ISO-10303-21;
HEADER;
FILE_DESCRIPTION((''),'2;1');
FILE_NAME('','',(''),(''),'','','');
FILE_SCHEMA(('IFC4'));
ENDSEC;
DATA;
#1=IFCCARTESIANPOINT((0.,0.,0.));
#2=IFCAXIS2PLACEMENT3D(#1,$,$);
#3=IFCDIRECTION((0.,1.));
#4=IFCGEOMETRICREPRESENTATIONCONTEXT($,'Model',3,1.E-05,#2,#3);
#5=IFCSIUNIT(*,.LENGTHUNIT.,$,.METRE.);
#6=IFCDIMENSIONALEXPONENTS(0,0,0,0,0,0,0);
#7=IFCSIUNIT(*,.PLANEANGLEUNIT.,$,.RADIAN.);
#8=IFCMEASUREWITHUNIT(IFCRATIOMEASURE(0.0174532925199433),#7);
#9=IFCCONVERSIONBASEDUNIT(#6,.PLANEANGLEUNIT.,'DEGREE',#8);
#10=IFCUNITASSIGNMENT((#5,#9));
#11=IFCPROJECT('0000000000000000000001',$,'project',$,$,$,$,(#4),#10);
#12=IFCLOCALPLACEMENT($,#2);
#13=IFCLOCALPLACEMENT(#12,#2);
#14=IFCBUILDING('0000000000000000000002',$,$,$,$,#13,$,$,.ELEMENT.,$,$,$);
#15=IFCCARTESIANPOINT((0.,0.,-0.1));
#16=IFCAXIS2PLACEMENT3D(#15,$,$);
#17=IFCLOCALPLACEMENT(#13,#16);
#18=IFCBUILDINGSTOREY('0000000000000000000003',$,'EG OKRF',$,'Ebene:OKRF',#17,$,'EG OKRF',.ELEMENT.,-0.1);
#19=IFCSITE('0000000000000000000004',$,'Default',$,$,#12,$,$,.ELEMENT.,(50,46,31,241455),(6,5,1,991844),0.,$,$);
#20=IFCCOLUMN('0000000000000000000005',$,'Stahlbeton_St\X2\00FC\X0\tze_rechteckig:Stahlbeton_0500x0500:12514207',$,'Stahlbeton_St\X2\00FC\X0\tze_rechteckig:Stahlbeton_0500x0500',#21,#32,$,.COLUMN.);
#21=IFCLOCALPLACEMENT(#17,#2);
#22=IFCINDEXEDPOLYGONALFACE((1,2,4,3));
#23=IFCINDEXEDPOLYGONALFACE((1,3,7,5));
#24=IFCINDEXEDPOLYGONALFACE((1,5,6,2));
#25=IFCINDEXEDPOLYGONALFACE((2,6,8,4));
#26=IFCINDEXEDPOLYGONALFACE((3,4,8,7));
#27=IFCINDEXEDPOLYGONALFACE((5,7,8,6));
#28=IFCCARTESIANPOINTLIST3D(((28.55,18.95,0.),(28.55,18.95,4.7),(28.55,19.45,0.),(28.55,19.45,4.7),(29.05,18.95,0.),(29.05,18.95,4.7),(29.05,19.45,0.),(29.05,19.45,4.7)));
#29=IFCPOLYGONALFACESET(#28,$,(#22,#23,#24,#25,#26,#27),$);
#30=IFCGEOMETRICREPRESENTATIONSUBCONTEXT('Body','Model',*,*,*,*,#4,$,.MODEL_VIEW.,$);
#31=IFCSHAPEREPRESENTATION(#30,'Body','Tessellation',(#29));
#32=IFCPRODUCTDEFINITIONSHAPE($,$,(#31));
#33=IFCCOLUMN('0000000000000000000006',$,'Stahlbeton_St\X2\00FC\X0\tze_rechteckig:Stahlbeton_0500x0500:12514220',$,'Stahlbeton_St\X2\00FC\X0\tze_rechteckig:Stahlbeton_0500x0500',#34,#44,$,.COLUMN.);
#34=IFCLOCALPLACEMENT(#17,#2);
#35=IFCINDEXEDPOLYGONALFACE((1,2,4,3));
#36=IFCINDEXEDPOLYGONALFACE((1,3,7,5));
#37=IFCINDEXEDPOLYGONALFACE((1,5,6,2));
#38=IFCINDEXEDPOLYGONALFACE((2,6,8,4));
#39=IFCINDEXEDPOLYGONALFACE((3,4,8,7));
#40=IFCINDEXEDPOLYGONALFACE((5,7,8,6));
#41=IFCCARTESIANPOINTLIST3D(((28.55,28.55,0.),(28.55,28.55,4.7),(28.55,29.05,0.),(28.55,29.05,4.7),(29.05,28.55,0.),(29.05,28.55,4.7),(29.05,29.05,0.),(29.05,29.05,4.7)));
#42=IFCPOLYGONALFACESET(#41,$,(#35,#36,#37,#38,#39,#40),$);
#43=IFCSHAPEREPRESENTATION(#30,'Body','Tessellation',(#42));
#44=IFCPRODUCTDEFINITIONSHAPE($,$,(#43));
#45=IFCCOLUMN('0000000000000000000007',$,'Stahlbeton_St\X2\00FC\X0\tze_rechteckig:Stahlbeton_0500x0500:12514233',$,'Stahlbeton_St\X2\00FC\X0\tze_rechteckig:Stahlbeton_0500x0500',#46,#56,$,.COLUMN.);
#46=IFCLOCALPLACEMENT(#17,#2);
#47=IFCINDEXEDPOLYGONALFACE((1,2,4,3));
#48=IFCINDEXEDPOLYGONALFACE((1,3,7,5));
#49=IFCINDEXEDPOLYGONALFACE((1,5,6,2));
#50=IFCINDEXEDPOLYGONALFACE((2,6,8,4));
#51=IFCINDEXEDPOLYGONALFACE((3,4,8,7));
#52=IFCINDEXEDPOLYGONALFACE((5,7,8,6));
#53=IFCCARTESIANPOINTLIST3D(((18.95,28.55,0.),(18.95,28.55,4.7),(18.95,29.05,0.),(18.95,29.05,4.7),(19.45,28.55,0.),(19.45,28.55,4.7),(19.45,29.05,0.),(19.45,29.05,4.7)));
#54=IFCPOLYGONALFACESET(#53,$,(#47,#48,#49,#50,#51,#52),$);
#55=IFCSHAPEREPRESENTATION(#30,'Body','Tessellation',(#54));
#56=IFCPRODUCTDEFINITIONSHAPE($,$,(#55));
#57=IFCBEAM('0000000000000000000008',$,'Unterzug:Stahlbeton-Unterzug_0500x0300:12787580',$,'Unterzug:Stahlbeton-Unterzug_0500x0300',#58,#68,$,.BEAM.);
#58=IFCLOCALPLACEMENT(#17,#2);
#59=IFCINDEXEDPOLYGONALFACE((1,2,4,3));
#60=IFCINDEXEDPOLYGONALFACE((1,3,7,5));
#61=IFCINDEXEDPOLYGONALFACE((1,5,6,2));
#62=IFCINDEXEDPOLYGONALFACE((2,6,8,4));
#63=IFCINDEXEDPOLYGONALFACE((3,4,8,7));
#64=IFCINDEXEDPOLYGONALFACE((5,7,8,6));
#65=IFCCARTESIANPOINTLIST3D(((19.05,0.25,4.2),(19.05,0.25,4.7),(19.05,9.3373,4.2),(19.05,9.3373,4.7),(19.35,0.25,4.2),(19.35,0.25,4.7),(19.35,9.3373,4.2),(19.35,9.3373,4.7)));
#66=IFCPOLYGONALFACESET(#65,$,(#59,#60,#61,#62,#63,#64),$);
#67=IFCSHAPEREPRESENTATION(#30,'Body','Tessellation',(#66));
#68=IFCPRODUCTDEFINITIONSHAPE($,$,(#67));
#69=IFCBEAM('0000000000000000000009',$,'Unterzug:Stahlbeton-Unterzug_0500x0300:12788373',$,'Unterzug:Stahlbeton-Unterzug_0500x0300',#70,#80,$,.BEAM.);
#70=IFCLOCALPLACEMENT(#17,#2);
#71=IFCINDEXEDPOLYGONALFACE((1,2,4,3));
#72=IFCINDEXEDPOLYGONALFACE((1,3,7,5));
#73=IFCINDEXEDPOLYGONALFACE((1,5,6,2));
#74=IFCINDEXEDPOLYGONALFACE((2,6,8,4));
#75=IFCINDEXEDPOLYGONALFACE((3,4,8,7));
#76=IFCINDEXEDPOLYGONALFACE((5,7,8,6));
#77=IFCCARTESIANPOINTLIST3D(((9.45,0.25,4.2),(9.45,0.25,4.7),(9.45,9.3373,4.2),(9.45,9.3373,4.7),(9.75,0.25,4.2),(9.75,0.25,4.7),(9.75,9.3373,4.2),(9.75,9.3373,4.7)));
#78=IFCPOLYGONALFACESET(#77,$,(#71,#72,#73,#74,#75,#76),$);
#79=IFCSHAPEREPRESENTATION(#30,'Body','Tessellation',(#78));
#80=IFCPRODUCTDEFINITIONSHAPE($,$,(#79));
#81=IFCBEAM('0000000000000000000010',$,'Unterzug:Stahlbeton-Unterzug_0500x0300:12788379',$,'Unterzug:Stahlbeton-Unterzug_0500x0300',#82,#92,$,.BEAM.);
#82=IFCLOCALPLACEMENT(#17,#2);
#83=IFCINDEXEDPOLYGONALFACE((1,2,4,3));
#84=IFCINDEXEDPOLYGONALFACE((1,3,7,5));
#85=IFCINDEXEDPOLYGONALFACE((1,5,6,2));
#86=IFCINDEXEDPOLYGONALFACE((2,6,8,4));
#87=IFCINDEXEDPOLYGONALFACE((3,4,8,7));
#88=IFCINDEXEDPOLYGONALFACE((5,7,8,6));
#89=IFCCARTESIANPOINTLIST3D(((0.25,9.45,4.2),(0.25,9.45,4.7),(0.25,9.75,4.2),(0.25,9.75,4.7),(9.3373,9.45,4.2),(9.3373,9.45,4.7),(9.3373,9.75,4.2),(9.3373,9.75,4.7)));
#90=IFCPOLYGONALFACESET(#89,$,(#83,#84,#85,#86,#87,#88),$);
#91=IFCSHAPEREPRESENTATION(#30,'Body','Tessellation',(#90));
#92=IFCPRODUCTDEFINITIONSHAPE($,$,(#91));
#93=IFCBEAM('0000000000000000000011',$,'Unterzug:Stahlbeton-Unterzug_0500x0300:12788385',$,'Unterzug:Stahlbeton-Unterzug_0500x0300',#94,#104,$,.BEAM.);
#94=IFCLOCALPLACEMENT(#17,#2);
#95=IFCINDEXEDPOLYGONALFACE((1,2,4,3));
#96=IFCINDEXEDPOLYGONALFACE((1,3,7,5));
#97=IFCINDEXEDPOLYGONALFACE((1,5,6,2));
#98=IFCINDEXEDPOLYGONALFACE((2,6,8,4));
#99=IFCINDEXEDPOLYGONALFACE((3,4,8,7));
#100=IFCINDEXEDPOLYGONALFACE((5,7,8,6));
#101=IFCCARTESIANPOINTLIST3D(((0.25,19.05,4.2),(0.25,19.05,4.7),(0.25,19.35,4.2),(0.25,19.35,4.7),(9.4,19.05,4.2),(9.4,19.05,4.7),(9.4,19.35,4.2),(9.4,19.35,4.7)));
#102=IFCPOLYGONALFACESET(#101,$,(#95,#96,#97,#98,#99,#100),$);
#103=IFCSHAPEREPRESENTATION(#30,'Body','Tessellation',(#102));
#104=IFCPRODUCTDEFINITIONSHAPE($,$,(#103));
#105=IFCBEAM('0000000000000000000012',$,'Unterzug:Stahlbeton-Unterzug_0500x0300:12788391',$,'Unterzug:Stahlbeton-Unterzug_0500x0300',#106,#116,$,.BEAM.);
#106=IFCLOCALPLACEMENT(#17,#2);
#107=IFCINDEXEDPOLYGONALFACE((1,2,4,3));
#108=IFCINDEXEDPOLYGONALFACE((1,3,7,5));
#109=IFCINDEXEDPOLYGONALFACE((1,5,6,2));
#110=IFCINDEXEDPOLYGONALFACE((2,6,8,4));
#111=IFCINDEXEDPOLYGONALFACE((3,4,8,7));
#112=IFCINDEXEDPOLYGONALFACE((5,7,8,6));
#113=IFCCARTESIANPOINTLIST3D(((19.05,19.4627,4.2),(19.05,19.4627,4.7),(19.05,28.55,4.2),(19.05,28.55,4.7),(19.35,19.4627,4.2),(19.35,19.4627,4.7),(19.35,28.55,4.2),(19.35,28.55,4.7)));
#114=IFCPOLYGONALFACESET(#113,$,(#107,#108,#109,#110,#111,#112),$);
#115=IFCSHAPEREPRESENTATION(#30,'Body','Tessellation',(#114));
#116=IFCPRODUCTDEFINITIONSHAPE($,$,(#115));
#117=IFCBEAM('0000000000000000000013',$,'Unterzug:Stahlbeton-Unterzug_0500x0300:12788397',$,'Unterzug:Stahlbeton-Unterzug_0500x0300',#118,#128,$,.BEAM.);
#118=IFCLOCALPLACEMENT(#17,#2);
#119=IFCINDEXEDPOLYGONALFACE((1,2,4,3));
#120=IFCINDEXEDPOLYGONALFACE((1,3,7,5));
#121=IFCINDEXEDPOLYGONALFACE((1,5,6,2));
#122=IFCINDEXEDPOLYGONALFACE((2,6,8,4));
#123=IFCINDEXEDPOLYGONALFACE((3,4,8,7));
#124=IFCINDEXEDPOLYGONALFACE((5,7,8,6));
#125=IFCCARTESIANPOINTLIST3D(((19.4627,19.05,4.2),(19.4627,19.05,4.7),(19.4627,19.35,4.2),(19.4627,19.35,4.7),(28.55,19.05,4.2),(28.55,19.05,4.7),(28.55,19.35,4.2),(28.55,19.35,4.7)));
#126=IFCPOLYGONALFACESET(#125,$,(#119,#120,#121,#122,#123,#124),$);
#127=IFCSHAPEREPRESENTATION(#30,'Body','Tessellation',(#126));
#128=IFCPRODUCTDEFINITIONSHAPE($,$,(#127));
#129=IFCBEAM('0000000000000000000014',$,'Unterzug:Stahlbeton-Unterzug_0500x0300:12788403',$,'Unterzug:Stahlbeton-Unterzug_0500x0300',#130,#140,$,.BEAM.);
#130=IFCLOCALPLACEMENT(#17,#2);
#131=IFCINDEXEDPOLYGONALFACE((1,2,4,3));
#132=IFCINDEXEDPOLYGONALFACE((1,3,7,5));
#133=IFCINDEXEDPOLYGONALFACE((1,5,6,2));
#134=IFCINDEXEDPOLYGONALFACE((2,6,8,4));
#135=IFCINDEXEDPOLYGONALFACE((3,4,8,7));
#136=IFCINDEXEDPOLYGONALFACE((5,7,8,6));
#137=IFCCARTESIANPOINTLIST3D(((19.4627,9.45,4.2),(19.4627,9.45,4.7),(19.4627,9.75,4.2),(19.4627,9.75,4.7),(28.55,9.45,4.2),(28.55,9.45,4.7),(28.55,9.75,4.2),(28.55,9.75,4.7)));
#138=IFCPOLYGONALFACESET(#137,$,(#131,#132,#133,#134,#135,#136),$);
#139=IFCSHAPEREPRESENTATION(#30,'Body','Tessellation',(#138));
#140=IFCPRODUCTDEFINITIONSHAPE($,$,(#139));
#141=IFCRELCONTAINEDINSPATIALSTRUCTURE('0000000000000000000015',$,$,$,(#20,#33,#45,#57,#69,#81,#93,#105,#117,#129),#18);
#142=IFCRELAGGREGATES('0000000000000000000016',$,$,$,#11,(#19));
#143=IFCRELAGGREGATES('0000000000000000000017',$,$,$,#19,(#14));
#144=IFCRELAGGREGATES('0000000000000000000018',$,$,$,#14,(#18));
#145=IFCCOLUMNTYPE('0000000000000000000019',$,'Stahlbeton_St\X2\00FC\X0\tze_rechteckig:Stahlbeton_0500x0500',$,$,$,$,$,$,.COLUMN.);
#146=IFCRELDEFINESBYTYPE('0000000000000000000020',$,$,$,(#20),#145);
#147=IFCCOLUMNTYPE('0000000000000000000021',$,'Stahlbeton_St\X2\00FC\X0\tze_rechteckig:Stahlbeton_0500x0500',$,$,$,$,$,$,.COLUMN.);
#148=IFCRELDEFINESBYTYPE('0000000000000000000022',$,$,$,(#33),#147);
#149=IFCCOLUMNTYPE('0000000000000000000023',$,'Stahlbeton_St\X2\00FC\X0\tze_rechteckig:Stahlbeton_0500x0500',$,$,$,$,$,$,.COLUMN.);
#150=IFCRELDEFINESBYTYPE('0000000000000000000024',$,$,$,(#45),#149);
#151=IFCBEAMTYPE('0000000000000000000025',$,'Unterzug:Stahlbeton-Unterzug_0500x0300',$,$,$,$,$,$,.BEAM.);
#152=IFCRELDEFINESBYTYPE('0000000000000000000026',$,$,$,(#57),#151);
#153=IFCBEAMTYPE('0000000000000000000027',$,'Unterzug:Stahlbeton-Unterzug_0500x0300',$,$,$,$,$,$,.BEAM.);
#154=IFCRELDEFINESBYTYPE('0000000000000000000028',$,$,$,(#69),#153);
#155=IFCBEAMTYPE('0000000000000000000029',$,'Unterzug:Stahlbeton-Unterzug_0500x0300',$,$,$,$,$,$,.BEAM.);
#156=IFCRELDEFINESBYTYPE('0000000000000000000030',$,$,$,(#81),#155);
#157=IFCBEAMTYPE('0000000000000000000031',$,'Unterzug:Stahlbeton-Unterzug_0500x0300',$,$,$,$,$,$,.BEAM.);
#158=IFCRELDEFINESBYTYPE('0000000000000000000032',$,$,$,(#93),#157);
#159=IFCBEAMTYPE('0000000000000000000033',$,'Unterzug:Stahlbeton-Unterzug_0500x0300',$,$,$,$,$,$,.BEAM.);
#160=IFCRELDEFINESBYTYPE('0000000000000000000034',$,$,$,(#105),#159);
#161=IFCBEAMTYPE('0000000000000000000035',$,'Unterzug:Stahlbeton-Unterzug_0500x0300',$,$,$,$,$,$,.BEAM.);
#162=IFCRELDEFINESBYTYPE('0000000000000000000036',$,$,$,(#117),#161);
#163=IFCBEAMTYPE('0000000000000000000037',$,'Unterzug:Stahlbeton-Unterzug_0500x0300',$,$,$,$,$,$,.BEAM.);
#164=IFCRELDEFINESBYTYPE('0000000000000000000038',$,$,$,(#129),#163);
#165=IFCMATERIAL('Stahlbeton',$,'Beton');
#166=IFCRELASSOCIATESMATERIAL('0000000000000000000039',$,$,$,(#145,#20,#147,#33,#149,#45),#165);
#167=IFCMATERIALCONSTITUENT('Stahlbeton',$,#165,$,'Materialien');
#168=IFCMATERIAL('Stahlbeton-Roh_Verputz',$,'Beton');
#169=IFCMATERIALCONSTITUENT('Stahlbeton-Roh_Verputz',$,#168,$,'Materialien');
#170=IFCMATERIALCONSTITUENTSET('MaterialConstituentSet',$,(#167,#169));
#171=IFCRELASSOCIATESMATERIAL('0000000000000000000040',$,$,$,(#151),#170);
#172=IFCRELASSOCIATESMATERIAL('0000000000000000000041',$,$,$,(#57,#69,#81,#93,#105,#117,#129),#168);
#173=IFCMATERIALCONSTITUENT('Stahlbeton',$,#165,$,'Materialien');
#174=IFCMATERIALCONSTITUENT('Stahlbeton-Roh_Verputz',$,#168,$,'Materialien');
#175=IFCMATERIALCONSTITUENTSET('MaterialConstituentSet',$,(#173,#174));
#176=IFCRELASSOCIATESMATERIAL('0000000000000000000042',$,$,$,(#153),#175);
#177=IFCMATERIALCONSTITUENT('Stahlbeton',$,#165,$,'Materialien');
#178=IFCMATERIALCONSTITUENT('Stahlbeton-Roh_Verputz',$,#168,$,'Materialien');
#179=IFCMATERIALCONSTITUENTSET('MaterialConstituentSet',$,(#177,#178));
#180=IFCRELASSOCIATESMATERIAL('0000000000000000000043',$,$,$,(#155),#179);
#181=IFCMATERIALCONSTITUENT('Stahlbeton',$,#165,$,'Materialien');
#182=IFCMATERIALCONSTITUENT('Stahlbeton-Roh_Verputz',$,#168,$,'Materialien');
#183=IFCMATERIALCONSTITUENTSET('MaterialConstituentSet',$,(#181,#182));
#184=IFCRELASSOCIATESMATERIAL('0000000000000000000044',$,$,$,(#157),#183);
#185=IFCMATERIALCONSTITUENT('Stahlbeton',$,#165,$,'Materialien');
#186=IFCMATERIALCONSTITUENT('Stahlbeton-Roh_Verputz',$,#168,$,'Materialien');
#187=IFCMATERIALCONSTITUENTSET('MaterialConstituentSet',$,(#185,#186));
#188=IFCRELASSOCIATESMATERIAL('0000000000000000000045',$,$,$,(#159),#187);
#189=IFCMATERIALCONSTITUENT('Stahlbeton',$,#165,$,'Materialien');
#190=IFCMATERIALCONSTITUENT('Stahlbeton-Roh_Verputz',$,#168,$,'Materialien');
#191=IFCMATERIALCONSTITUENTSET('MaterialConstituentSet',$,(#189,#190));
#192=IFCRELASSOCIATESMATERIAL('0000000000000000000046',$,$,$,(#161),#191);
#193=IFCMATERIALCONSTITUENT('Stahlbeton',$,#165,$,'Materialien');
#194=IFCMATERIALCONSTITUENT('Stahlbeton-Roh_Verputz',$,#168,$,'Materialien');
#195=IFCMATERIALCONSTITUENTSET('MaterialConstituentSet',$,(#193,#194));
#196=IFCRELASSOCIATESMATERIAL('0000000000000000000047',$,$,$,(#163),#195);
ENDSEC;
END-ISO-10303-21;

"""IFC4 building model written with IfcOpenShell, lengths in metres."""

from ifc_helpers import new_model, entity, si_unit, converted_unit, direction, frame, origin, place, context, subcontext, project, spatial, indexed_curve, outline, extrude, source, transform, mapped, material, constituent, constituent_set, type_object, type_shapes, element, save


model = new_model("IFC4")

# Units and contexts
model_context = context("Model", 3, precision=1e-05, world=origin(), true_north=direction((0.0, 1.0)))
body_context = subcontext(model_context, "Body", "Model", "MODEL_VIEW")
ifc_project = project(units=[si_unit("LENGTHUNIT", "METRE"), converted_unit("PLANEANGLEUNIT", "DEGREE", entity("IfcRatioMeasure", 0.0174532925199433), si_unit("PLANEANGLEUNIT", "RADIAN"), dimensions=[0, 0, 0, 0, 0, 0, 0])], contexts=[model_context])

# Site, building, storey
site_placement = place(None, origin())
site = spatial("IfcSite", under=ifc_project, at=site_placement, Name="Default", CompositionType="ELEMENT", RefLatitude=(50, 46, 31, 241455), RefLongitude=(6, 5, 1, 991844), RefElevation=0.0)
building_placement = place(site_placement, origin())
building = spatial("IfcBuilding", under=site, at=building_placement, CompositionType="ELEMENT")
storey_placement = place(building_placement, frame((0.0, 0.0, -0.1)))
storey = spatial("IfcBuildingStorey", under=building, at=storey_placement, Name="EG OKRF", ObjectType="Ebene:OKRF", LongName="EG OKRF", CompositionType="ELEMENT", Elevation=-0.1)

# Columns
ifc_material_1 = material(Name="Stahlbeton", Category="Beton")
column_type_1 = type_object("IfcColumnType", Name="Stahlbeton_Stütze_rechteckig:Stahlbeton_0500x0500", PredefinedType="COLUMN", material=ifc_material_1)
shared_shape_1 = source(origin(), body_context, "Body", "SweptSolid", [
    extrude(outline(indexed_curve([(-0.25, -0.25), (0.25, -0.25), (0.25, 0.25), (-0.25, 0.25), (-0.25, -0.25)], self_intersect=False)), frame((28.8, 19.2, -0.1), z_axis=(0.0, 0.0, 1.0), x_axis=(0.0, -1.0, 0.0)), (0.0, 0.0, 1.0), 4.7),
])
type_shapes(column_type_1, [shared_shape_1])
column_1_placement = place(storey_placement, frame((0.0, 0.0, 0.1)))
element("IfcColumn", 1, at=column_1_placement, inside=storey, type_object=column_type_1, material=ifc_material_1, Name="Stahlbeton_Stütze_rechteckig:Stahlbeton_0500x0500:12514207", ObjectType="Stahlbeton_Stütze_rechteckig:Stahlbeton_0500x0500", PredefinedType="COLUMN", context=body_context, shape_type="MappedRepresentation", body=[
    mapped(shared_shape_1, transform((0.0, 0.0, 0.0), scale=1.0)),
])
column_type_2 = type_object("IfcColumnType", Name="Stahlbeton_Stütze_rechteckig:Stahlbeton_0500x0500", PredefinedType="COLUMN", material=ifc_material_1)
shared_shape_2 = source(origin(), body_context, "Body", "SweptSolid", [
    extrude(outline(indexed_curve([(-0.25, -0.25), (0.25, -0.25), (0.25, 0.25), (-0.25, 0.25), (-0.25, -0.25)], self_intersect=False)), frame((28.8, 28.8, -0.1), z_axis=(0.0, 0.0, 1.0), x_axis=(0.0, -1.0, 0.0)), (0.0, 0.0, 1.0), 4.7),
])
type_shapes(column_type_2, [shared_shape_2])
column_2_placement = place(storey_placement, frame((0.0, 0.0, 0.1)))
element("IfcColumn", 2, at=column_2_placement, inside=storey, type_object=column_type_2, material=ifc_material_1, Name="Stahlbeton_Stütze_rechteckig:Stahlbeton_0500x0500:12514220", ObjectType="Stahlbeton_Stütze_rechteckig:Stahlbeton_0500x0500", PredefinedType="COLUMN", context=body_context, shape_type="MappedRepresentation", body=[
    mapped(shared_shape_2, transform((0.0, 0.0, 0.0), scale=1.0)),
])
column_type_3 = type_object("IfcColumnType", Name="Stahlbeton_Stütze_rechteckig:Stahlbeton_0500x0500", PredefinedType="COLUMN", material=ifc_material_1)
shared_shape_3 = source(origin(), body_context, "Body", "SweptSolid", [
    extrude(outline(indexed_curve([(-0.25, -0.25), (0.25, -0.25), (0.25, 0.25), (-0.25, 0.25), (-0.25, -0.25)], self_intersect=False)), frame((19.2, 28.8, -0.1), z_axis=(0.0, 0.0, 1.0), x_axis=(0.0, -1.0, 0.0)), (0.0, 0.0, 1.0), 4.7),
])
type_shapes(column_type_3, [shared_shape_3])
column_3_placement = place(storey_placement, frame((0.0, 0.0, 0.1)))
element("IfcColumn", 3, at=column_3_placement, inside=storey, type_object=column_type_3, material=ifc_material_1, Name="Stahlbeton_Stütze_rechteckig:Stahlbeton_0500x0500:12514233", ObjectType="Stahlbeton_Stütze_rechteckig:Stahlbeton_0500x0500", PredefinedType="COLUMN", context=body_context, shape_type="MappedRepresentation", body=[
    mapped(shared_shape_3, transform((0.0, 0.0, 0.0), scale=1.0)),
])

# Beams
ifc_material_2 = material(Name="Stahlbeton-Roh_Verputz", Category="Beton")
ifc_constituent_1 = constituent(ifc_material_1, Name="Stahlbeton", Category="Materialien")
ifc_constituent_2 = constituent(ifc_material_2, Name="Stahlbeton-Roh_Verputz", Category="Materialien")
ifc_constituent_set_1 = constituent_set(constituents=[ifc_constituent_1, ifc_constituent_2], Name="MaterialConstituentSet")
beam_type_1 = type_object("IfcBeamType", Name="Unterzug:Stahlbeton-Unterzug_0500x0300", PredefinedType="BEAM", material=ifc_constituent_set_1)
shared_shape_4 = source(origin(), body_context, "Body", "SweptSolid", [
    extrude(outline(indexed_curve([(-0.15, -0.25), (0.15, -0.25), (0.15, 0.25), (-0.15, 0.25), (-0.15, -0.25)], self_intersect=False)), frame((19.2, 9.3373, 4.35), z_axis=(0.0, -1.0, 0.0), x_axis=(-1.0, 0.0, 0.0)), (0.0, 0.0, 1.0), 9.0873),
])
type_shapes(beam_type_1, [shared_shape_4])
beam_1_placement = place(storey_placement, frame((0.0, 0.0, 0.1)))
element("IfcBeam", 4, at=beam_1_placement, inside=storey, type_object=beam_type_1, material=ifc_material_2, Name="Unterzug:Stahlbeton-Unterzug_0500x0300:12787580", ObjectType="Unterzug:Stahlbeton-Unterzug_0500x0300", PredefinedType="BEAM", context=body_context, shape_type="MappedRepresentation", body=[
    mapped(shared_shape_4, transform((0.0, 0.0, 0.0), scale=1.0)),
])
ifc_constituent_3 = constituent(ifc_material_1, Name="Stahlbeton", Category="Materialien")
ifc_constituent_4 = constituent(ifc_material_2, Name="Stahlbeton-Roh_Verputz", Category="Materialien")
ifc_constituent_set_2 = constituent_set(constituents=[ifc_constituent_3, ifc_constituent_4], Name="MaterialConstituentSet")
beam_type_2 = type_object("IfcBeamType", Name="Unterzug:Stahlbeton-Unterzug_0500x0300", PredefinedType="BEAM", material=ifc_constituent_set_2)
shared_shape_5 = source(origin(), body_context, "Body", "SweptSolid", [
    extrude(outline(indexed_curve([(-0.15, -0.25), (0.15, -0.25), (0.15, 0.25), (-0.15, 0.25), (-0.15, -0.25)], self_intersect=False)), frame((9.6, 9.3373, 4.35), z_axis=(0.0, -1.0, 0.0), x_axis=(-1.0, 0.0, 0.0)), (0.0, 0.0, 1.0), 9.0873),
])
type_shapes(beam_type_2, [shared_shape_5])
beam_2_placement = place(storey_placement, frame((0.0, 0.0, 0.1)))
element("IfcBeam", 5, at=beam_2_placement, inside=storey, type_object=beam_type_2, material=ifc_material_2, Name="Unterzug:Stahlbeton-Unterzug_0500x0300:12788373", ObjectType="Unterzug:Stahlbeton-Unterzug_0500x0300", PredefinedType="BEAM", context=body_context, shape_type="MappedRepresentation", body=[
    mapped(shared_shape_5, transform((0.0, 0.0, 0.0), scale=1.0)),
])
ifc_constituent_5 = constituent(ifc_material_1, Name="Stahlbeton", Category="Materialien")
ifc_constituent_6 = constituent(ifc_material_2, Name="Stahlbeton-Roh_Verputz", Category="Materialien")
ifc_constituent_set_3 = constituent_set(constituents=[ifc_constituent_5, ifc_constituent_6], Name="MaterialConstituentSet")
beam_type_3 = type_object("IfcBeamType", Name="Unterzug:Stahlbeton-Unterzug_0500x0300", PredefinedType="BEAM", material=ifc_constituent_set_3)
shared_shape_6 = source(origin(), body_context, "Body", "SweptSolid", [
    extrude(outline(indexed_curve([(-0.25, -0.15), (0.25, -0.15), (0.25, 0.15), (-0.25, 0.15), (-0.25, -0.15)], self_intersect=False)), frame((9.3373, 9.6, 4.35), z_axis=(-1.0, 0.0, 0.0), x_axis=(0.0, 0.0, -1.0)), (0.0, 0.0, 1.0), 9.0873),
])
type_shapes(beam_type_3, [shared_shape_6])
beam_3_placement = place(storey_placement, frame((0.0, 0.0, 0.1)))
element("IfcBeam", 6, at=beam_3_placement, inside=storey, type_object=beam_type_3, material=ifc_material_2, Name="Unterzug:Stahlbeton-Unterzug_0500x0300:12788379", ObjectType="Unterzug:Stahlbeton-Unterzug_0500x0300", PredefinedType="BEAM", context=body_context, shape_type="MappedRepresentation", body=[
    mapped(shared_shape_6, transform((0.0, 0.0, 0.0), scale=1.0)),
])
ifc_constituent_7 = constituent(ifc_material_1, Name="Stahlbeton", Category="Materialien")
ifc_constituent_8 = constituent(ifc_material_2, Name="Stahlbeton-Roh_Verputz", Category="Materialien")
ifc_constituent_set_4 = constituent_set(constituents=[ifc_constituent_7, ifc_constituent_8], Name="MaterialConstituentSet")
beam_type_4 = type_object("IfcBeamType", Name="Unterzug:Stahlbeton-Unterzug_0500x0300", PredefinedType="BEAM", material=ifc_constituent_set_4)
shared_shape_7 = source(origin(), body_context, "Body", "SweptSolid", [
    extrude(outline(indexed_curve([(-0.25, -0.15), (0.25, -0.15), (0.25, 0.15), (-0.25, 0.15), (-0.25, -0.15)], self_intersect=False)), frame((9.4, 19.2, 4.35), z_axis=(-1.0, 0.0, 0.0), x_axis=(0.0, 0.0, -1.0)), (0.0, 0.0, 1.0), 9.15),
])
type_shapes(beam_type_4, [shared_shape_7])
beam_4_placement = place(storey_placement, frame((0.0, 0.0, 0.1)))
element("IfcBeam", 7, at=beam_4_placement, inside=storey, type_object=beam_type_4, material=ifc_material_2, Name="Unterzug:Stahlbeton-Unterzug_0500x0300:12788385", ObjectType="Unterzug:Stahlbeton-Unterzug_0500x0300", PredefinedType="BEAM", context=body_context, shape_type="MappedRepresentation", body=[
    mapped(shared_shape_7, transform((0.0, 0.0, 0.0), scale=1.0)),
])
ifc_constituent_9 = constituent(ifc_material_1, Name="Stahlbeton", Category="Materialien")
ifc_constituent_10 = constituent(ifc_material_2, Name="Stahlbeton-Roh_Verputz", Category="Materialien")
ifc_constituent_set_5 = constituent_set(constituents=[ifc_constituent_9, ifc_constituent_10], Name="MaterialConstituentSet")
beam_type_5 = type_object("IfcBeamType", Name="Unterzug:Stahlbeton-Unterzug_0500x0300", PredefinedType="BEAM", material=ifc_constituent_set_5)
shared_shape_8 = source(origin(), body_context, "Body", "SweptSolid", [
    extrude(outline(indexed_curve([(-0.15, -0.25), (0.15, -0.25), (0.15, 0.25), (-0.15, 0.25), (-0.15, -0.25)], self_intersect=False)), frame((19.2, 19.4627, 4.35), z_axis=(0.0, 1.0, 0.0), x_axis=(-1.0, 0.0, 0.0)), (0.0, 0.0, 1.0), 9.0873),
])
type_shapes(beam_type_5, [shared_shape_8])
beam_5_placement = place(storey_placement, frame((0.0, 0.0, 0.1)))
element("IfcBeam", 8, at=beam_5_placement, inside=storey, type_object=beam_type_5, material=ifc_material_2, Name="Unterzug:Stahlbeton-Unterzug_0500x0300:12788391", ObjectType="Unterzug:Stahlbeton-Unterzug_0500x0300", PredefinedType="BEAM", context=body_context, shape_type="MappedRepresentation", body=[
    mapped(shared_shape_8, transform((0.0, 0.0, 0.0), scale=1.0)),
])
ifc_constituent_11 = constituent(ifc_material_1, Name="Stahlbeton", Category="Materialien")
ifc_constituent_12 = constituent(ifc_material_2, Name="Stahlbeton-Roh_Verputz", Category="Materialien")
ifc_constituent_set_6 = constituent_set(constituents=[ifc_constituent_11, ifc_constituent_12], Name="MaterialConstituentSet")
beam_type_6 = type_object("IfcBeamType", Name="Unterzug:Stahlbeton-Unterzug_0500x0300", PredefinedType="BEAM", material=ifc_constituent_set_6)
shared_shape_9 = source(origin(), body_context, "Body", "SweptSolid", [
    extrude(outline(indexed_curve([(-0.25, -0.15), (0.25, -0.15), (0.25, 0.15), (-0.25, 0.15), (-0.25, -0.15)], self_intersect=False)), frame((19.4627, 19.2, 4.35), z_axis=(1.0, 0.0, 0.0), x_axis=(0.0, 0.0, -1.0)), (0.0, 0.0, 1.0), 9.0873),
])
type_shapes(beam_type_6, [shared_shape_9])
beam_6_placement = place(storey_placement, frame((0.0, 0.0, 0.1)))
element("IfcBeam", 9, at=beam_6_placement, inside=storey, type_object=beam_type_6, material=ifc_material_2, Name="Unterzug:Stahlbeton-Unterzug_0500x0300:12788397", ObjectType="Unterzug:Stahlbeton-Unterzug_0500x0300", PredefinedType="BEAM", context=body_context, shape_type="MappedRepresentation", body=[
    mapped(shared_shape_9, transform((0.0, 0.0, 0.0), scale=1.0)),
])
ifc_constituent_13 = constituent(ifc_material_1, Name="Stahlbeton", Category="Materialien")
ifc_constituent_14 = constituent(ifc_material_2, Name="Stahlbeton-Roh_Verputz", Category="Materialien")
ifc_constituent_set_7 = constituent_set(constituents=[ifc_constituent_13, ifc_constituent_14], Name="MaterialConstituentSet")
beam_type_7 = type_object("IfcBeamType", Name="Unterzug:Stahlbeton-Unterzug_0500x0300", PredefinedType="BEAM", material=ifc_constituent_set_7)
shared_shape_10 = source(origin(), body_context, "Body", "SweptSolid", [
    extrude(outline(indexed_curve([(-0.25, -0.15), (0.25, -0.15), (0.25, 0.15), (-0.25, 0.15), (-0.25, -0.15)], self_intersect=False)), frame((19.4627, 9.6, 4.35), z_axis=(1.0, 0.0, 0.0), x_axis=(0.0, 0.0, -1.0)), (0.0, 0.0, 1.0), 9.0873),
])
type_shapes(beam_type_7, [shared_shape_10])
beam_7_placement = place(storey_placement, frame((0.0, 0.0, 0.1)))
element("IfcBeam", 10, at=beam_7_placement, inside=storey, type_object=beam_type_7, material=ifc_material_2, Name="Unterzug:Stahlbeton-Unterzug_0500x0300:12788403", ObjectType="Unterzug:Stahlbeton-Unterzug_0500x0300", PredefinedType="BEAM", context=body_context, shape_type="MappedRepresentation", body=[
    mapped(shared_shape_10, transform((0.0, 0.0, 0.0), scale=1.0)),
])

save(model, "model.ifc")
